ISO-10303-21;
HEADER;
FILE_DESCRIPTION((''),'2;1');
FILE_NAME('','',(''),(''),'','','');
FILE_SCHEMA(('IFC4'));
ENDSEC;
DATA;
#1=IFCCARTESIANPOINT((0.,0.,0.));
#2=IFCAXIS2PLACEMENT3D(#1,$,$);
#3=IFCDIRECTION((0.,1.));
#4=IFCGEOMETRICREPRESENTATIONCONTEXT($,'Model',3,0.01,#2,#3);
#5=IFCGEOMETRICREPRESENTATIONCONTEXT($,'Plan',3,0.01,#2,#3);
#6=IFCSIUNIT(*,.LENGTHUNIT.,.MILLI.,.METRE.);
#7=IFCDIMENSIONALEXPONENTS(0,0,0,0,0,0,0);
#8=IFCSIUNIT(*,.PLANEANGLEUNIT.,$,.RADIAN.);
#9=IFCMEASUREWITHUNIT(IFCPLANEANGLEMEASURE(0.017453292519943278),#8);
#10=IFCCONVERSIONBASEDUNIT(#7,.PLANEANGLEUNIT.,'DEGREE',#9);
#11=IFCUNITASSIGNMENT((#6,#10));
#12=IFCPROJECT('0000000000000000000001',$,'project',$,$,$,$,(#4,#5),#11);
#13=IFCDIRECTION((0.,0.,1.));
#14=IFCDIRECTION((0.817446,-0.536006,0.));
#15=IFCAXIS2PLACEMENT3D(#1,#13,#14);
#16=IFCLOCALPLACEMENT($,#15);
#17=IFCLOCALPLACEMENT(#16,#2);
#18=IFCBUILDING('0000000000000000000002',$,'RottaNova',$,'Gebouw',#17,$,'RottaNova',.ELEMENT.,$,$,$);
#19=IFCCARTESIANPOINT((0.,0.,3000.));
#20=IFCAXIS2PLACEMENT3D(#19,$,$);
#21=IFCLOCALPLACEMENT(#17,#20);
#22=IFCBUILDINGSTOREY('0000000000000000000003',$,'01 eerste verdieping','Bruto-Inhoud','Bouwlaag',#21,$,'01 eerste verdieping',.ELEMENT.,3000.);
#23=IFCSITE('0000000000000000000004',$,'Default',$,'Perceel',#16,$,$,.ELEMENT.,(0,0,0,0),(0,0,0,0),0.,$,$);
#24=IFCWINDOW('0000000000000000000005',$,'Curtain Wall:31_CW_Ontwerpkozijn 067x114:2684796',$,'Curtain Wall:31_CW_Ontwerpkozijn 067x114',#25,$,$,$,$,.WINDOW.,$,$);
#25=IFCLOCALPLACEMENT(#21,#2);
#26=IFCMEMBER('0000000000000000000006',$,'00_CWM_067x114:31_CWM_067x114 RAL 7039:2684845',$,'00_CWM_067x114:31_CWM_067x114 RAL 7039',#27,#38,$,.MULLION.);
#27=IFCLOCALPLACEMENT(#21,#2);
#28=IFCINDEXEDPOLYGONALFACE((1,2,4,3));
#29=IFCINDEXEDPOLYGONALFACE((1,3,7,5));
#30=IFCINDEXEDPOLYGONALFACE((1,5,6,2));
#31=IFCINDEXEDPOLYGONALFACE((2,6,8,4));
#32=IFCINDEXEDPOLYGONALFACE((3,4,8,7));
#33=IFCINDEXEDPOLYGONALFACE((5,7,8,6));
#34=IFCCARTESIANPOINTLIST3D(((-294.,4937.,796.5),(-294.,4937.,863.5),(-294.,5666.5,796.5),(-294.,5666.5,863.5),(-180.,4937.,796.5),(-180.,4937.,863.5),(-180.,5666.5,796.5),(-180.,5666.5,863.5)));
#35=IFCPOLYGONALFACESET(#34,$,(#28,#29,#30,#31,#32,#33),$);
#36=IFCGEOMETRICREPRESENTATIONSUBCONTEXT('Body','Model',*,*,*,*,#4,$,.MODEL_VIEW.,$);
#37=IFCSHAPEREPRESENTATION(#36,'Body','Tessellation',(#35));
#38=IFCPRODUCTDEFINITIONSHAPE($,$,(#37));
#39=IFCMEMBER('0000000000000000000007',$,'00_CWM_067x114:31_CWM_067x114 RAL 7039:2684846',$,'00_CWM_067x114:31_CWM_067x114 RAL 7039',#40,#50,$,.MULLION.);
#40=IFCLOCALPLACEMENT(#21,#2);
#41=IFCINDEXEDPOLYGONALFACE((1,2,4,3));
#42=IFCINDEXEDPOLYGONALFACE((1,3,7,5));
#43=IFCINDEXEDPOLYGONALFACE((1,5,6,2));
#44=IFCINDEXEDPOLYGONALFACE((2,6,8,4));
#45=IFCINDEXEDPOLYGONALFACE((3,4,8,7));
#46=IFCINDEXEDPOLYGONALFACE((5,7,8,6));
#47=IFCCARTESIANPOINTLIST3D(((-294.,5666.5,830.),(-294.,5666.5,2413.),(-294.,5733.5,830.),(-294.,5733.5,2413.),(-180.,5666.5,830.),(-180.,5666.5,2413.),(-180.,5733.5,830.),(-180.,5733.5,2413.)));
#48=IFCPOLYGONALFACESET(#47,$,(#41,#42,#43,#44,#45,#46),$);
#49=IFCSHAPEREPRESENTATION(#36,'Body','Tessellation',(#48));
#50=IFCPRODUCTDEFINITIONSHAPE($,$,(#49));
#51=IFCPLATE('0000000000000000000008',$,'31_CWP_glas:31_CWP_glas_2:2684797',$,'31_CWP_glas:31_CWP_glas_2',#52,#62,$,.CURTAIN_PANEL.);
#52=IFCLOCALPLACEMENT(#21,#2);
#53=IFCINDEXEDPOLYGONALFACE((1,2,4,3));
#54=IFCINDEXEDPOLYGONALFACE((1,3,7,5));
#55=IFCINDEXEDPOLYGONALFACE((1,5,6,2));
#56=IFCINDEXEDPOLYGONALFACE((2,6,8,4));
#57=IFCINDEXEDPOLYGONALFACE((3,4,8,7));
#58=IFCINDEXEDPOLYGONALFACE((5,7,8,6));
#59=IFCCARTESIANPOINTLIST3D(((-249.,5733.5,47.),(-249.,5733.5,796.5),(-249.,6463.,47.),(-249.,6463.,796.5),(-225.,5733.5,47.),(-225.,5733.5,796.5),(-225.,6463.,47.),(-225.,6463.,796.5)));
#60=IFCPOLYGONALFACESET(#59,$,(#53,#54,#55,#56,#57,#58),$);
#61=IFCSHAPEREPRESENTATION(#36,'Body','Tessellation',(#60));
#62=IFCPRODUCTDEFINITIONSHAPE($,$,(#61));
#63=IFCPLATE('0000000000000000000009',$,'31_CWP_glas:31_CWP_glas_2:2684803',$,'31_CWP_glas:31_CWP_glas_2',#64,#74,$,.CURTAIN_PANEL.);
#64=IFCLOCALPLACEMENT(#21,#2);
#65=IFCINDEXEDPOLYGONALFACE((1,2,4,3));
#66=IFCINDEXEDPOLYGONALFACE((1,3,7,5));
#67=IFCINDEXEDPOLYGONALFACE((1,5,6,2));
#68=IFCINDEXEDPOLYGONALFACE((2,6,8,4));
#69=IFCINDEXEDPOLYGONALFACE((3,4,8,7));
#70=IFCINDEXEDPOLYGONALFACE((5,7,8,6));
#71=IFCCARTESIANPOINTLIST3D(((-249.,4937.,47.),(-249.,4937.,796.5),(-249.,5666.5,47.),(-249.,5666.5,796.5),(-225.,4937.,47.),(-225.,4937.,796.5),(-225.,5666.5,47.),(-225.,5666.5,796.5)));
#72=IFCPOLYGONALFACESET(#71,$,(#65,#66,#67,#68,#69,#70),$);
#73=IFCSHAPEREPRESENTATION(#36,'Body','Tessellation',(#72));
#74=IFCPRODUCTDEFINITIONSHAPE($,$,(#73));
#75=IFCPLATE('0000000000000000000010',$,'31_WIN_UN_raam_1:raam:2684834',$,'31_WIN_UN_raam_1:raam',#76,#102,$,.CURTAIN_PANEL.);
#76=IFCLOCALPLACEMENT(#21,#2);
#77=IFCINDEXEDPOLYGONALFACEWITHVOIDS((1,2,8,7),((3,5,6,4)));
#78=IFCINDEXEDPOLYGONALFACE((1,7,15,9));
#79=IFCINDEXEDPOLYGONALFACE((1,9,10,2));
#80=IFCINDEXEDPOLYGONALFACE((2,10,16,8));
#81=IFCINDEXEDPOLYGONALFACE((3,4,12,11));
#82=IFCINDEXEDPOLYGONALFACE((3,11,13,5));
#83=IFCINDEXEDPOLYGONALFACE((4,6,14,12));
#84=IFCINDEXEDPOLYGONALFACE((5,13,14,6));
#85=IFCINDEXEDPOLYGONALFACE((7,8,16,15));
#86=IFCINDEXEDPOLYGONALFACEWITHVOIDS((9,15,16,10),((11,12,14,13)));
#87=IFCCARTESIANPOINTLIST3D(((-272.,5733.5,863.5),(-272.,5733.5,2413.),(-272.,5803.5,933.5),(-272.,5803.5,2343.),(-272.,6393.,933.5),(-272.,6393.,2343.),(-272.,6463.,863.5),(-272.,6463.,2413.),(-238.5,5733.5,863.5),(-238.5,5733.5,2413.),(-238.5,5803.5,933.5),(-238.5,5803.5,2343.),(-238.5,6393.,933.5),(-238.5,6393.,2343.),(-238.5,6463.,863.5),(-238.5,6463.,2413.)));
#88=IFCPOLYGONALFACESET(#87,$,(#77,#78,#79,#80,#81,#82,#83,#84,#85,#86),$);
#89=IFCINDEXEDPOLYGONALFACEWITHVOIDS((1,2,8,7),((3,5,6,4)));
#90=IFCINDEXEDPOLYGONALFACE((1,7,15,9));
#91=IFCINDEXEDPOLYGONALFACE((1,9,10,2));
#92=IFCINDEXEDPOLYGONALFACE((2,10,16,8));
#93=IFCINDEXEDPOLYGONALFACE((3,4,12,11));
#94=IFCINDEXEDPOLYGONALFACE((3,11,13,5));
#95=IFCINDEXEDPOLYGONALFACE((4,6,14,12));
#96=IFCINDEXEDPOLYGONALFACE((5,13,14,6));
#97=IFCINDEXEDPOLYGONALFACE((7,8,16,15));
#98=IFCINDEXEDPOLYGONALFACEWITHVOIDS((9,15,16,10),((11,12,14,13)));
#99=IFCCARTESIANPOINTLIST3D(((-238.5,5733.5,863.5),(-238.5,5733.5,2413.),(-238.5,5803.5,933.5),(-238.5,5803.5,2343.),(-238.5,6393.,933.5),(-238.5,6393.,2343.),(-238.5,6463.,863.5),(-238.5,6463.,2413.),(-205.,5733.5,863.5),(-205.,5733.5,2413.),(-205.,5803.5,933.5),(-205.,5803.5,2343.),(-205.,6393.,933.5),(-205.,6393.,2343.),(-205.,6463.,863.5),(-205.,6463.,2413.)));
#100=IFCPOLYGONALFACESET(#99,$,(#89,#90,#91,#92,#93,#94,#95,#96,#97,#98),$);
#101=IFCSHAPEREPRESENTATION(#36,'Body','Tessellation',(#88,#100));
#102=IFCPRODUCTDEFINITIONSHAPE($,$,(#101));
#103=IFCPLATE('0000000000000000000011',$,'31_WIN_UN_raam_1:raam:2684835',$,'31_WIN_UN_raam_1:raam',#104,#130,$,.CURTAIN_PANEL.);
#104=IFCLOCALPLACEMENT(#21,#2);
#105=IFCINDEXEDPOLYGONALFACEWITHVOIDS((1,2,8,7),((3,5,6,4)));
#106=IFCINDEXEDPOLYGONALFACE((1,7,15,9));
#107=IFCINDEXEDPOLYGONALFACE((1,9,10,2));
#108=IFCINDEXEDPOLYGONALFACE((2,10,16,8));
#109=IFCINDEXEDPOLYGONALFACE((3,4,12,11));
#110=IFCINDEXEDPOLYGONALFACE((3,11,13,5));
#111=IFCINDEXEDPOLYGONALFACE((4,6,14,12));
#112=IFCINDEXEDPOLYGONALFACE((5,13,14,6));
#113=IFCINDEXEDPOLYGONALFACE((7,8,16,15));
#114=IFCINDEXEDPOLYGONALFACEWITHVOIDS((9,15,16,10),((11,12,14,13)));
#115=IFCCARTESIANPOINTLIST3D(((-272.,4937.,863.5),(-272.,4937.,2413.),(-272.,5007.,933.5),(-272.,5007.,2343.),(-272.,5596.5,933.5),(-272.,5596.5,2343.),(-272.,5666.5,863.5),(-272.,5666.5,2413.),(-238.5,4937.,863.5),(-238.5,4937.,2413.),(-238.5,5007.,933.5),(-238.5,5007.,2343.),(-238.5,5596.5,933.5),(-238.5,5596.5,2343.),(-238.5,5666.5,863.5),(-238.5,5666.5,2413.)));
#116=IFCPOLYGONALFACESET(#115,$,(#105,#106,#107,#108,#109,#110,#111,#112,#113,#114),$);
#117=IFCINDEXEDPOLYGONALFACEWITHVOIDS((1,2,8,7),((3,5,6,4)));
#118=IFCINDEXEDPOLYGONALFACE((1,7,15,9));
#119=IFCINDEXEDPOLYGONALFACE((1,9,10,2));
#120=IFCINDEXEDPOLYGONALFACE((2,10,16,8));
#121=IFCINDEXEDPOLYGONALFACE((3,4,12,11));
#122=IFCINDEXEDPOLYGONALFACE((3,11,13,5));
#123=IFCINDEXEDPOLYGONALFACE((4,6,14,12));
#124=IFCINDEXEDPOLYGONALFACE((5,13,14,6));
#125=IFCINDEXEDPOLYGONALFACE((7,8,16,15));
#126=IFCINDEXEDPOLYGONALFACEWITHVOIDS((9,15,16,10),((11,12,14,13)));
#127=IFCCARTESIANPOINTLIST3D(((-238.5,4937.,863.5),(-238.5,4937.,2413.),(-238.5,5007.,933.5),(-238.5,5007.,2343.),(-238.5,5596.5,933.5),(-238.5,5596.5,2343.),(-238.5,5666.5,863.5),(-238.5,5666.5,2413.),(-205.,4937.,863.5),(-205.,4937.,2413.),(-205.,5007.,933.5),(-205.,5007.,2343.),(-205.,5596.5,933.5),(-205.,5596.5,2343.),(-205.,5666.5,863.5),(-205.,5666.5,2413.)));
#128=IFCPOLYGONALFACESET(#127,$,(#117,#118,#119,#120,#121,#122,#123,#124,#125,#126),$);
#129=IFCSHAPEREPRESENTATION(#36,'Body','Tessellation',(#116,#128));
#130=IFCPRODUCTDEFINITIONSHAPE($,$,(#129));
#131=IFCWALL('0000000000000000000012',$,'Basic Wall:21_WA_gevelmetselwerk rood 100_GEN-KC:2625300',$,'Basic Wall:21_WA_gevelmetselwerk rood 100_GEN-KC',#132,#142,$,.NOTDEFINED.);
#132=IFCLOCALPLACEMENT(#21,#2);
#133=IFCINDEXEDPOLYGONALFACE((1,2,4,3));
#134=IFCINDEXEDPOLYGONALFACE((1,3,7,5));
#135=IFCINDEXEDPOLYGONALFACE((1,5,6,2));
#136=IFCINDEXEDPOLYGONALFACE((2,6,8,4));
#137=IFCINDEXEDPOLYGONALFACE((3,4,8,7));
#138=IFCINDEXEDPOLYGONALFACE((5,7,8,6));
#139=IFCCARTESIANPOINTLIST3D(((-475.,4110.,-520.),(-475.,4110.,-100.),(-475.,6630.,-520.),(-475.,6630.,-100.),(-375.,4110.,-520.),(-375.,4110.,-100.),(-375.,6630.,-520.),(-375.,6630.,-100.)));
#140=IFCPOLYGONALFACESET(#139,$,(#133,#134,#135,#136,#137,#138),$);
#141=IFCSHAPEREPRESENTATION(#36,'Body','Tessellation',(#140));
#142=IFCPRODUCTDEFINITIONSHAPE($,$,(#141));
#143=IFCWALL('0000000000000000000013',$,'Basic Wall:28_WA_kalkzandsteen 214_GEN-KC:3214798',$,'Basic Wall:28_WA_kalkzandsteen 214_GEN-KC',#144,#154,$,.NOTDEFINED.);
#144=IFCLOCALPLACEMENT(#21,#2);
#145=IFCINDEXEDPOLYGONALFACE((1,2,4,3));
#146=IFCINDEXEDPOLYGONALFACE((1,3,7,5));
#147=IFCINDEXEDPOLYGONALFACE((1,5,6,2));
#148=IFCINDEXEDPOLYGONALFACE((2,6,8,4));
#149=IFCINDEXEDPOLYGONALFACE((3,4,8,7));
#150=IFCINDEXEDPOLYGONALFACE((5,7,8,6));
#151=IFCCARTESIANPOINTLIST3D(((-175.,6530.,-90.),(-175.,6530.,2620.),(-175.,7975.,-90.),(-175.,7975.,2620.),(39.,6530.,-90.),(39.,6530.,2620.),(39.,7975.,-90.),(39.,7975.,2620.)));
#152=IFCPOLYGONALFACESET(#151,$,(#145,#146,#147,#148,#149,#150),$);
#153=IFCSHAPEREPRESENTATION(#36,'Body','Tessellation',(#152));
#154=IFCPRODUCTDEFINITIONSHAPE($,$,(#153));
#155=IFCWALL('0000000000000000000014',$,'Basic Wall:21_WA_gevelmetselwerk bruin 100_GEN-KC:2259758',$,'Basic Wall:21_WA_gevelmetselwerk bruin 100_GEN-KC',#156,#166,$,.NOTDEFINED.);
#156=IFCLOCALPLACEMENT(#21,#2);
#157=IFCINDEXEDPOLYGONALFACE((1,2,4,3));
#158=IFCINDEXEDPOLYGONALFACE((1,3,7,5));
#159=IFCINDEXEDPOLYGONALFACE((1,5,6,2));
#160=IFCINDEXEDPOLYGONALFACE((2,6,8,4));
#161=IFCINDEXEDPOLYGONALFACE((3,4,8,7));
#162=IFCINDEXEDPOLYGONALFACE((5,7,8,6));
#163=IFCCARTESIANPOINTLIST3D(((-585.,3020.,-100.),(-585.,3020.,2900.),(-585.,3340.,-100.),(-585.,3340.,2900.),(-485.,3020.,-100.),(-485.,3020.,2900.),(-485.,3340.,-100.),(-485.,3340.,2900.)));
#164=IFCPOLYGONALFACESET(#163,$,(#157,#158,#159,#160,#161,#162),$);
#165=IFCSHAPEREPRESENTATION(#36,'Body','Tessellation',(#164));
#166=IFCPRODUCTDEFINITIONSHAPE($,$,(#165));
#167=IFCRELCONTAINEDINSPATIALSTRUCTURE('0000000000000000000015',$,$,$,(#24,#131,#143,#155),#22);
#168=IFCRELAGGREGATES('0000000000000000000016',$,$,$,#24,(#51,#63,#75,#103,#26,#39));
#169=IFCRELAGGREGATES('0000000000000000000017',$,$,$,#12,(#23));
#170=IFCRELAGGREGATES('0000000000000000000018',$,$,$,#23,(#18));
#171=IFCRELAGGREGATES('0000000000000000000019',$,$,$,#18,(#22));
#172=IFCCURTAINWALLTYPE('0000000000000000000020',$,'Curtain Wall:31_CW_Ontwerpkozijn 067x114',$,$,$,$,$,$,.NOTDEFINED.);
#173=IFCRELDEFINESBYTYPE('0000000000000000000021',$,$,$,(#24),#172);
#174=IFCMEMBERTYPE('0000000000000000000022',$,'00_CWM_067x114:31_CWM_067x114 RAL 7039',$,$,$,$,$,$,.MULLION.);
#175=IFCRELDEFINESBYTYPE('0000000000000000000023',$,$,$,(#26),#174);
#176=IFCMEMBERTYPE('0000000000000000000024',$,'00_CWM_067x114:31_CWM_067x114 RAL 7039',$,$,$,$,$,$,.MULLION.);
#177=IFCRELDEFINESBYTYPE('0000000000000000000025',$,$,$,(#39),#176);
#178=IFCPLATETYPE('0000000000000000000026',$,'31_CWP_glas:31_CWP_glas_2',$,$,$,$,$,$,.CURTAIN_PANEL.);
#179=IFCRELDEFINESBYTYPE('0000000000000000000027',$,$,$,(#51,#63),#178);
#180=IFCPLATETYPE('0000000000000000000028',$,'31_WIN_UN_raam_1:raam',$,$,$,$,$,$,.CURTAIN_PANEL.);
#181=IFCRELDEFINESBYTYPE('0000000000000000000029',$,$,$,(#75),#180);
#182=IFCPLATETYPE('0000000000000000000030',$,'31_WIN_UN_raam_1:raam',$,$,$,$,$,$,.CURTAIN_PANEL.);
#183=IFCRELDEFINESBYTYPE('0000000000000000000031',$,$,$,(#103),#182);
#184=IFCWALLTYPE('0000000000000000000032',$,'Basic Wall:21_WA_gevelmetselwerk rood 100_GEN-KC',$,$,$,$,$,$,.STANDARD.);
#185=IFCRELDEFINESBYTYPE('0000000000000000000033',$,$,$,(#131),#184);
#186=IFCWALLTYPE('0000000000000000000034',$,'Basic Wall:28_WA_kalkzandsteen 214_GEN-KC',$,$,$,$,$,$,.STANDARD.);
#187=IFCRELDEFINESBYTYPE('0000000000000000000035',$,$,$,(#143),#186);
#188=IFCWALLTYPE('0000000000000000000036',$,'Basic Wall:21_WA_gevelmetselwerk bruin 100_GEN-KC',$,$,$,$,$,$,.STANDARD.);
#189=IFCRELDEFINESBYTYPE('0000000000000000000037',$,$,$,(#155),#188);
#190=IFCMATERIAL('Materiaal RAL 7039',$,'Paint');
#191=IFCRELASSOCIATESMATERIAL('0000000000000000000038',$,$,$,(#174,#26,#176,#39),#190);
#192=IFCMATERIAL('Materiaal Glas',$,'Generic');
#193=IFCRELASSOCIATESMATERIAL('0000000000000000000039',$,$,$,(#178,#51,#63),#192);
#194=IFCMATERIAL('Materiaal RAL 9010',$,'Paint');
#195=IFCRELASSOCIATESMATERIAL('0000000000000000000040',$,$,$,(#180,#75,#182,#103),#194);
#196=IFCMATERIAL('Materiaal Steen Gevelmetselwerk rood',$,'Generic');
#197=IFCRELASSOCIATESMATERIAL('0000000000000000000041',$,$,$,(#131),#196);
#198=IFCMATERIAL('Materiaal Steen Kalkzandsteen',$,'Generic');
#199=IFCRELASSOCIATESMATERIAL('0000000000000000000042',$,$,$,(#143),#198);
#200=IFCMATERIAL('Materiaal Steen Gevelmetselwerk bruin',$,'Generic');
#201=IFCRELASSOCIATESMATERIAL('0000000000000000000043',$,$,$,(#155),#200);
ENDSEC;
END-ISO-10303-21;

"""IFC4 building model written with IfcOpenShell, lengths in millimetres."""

from ifc_helpers import new_model, entity, si_unit, converted_unit, direction, frame, origin, place, context, subcontext, project, spatial, indexed_curve, outline, extrude, source, transform, mapped, material, type_object, type_shapes, element, aggregate, save


model = new_model("IFC4")

# Units and contexts
model_context = context("Model", 3, precision=0.01, world=origin(), true_north=direction((0.0, 1.0)))
plan_context = context("Plan", 3, precision=0.01, world=origin(), true_north=direction((0.0, 1.0)))
body_context = subcontext(model_context, "Body", "Model", "MODEL_VIEW")
ifc_project = project(units=[si_unit("LENGTHUNIT", "METRE", prefix="MILLI"), converted_unit("PLANEANGLEUNIT", "DEGREE", entity("IfcPlaneAngleMeasure", 0.017453292519943278), si_unit("PLANEANGLEUNIT", "RADIAN"), dimensions=[0, 0, 0, 0, 0, 0, 0])], contexts=[model_context, plan_context])

# Site, building, storey
site_placement = place(None, frame((0.0, 0.0, 0.0), z_axis=(0.0, 0.0, 1.0), x_axis=(0.817446, -0.536006, 0.0)))
site = spatial("IfcSite", under=ifc_project, at=site_placement, Name="Default", ObjectType="Perceel", CompositionType="ELEMENT", RefLatitude=(0, 0, 0, 0), RefLongitude=(0, 0, 0, 0), RefElevation=0.0)
building_placement = place(site_placement, origin())
building = spatial("IfcBuilding", under=site, at=building_placement, Name="RottaNova", ObjectType="Gebouw", LongName="RottaNova", CompositionType="ELEMENT")
storey_placement = place(building_placement, frame((0.0, 0.0, 3000.0)))
storey = spatial("IfcBuildingStorey", under=building, at=storey_placement, Name="01 eerste verdieping", Description="Bruto-Inhoud", ObjectType="Bouwlaag", LongName="01 eerste verdieping", CompositionType="ELEMENT", Elevation=3000.0)

# Window, members, plates
curtain_wall_type = type_object("IfcCurtainWallType", Name="Curtain Wall:31_CW_Ontwerpkozijn 067x114", PredefinedType="NOTDEFINED")
window_placement = place(storey_placement, frame((0.0, 0.0, -3000.0)))
window = element("IfcWindow", 1, at=window_placement, inside=storey, type_object=curtain_wall_type, Name="Curtain Wall:31_CW_Ontwerpkozijn 067x114:2684796", ObjectType="Curtain Wall:31_CW_Ontwerpkozijn 067x114", PredefinedType="WINDOW")
ifc_material_1 = material(Name="Materiaal RAL 7039", Category="Paint")
member_type_1 = type_object("IfcMemberType", Name="00_CWM_067x114:31_CWM_067x114 RAL 7039", PredefinedType="MULLION", material=ifc_material_1)
shared_shape_1 = source(origin(), body_context, "Body", "SweptSolid", [
    extrude(outline(indexed_curve([(-33.5, -57.0), (33.5, -57.0), (33.5, 57.0), (-33.5, 57.0), (-33.5, -57.0)], self_intersect=False)), frame((0.0, 57.0, -729.5), z_axis=(0.0, 0.0, 1.0), x_axis=(-1.0, 0.0, 0.0)), (0.0, 0.0, 1.0), 729.5),
])
type_shapes(member_type_1, [shared_shape_1])
member_1_placement = place(window_placement, frame((-180.0, 4937.0, 3830.0), z_axis=(0.0, -1.0, 0.0), x_axis=(0.0, 0.0, 1.0)))
member_1 = element("IfcMember", 2, at=member_1_placement, type_object=member_type_1, material=ifc_material_1, Name="00_CWM_067x114:31_CWM_067x114 RAL 7039:2684845", ObjectType="00_CWM_067x114:31_CWM_067x114 RAL 7039", PredefinedType="MULLION", context=body_context, shape_type="MappedRepresentation", body=[
    mapped(shared_shape_1, transform((0.0, 0.0, 0.0), scale=1.0)),
])
member_type_2 = type_object("IfcMemberType", Name="00_CWM_067x114:31_CWM_067x114 RAL 7039", PredefinedType="MULLION", material=ifc_material_1)
shared_shape_2 = source(origin(), body_context, "Body", "SweptSolid", [
    extrude(outline(indexed_curve([(-33.5, -57.0), (33.5, -57.0), (33.5, 57.0), (-33.5, 57.0), (-33.5, -57.0)], self_intersect=False)), frame((0.0, 57.0, -1583.0), z_axis=(0.0, 0.0, 1.0), x_axis=(-1.0, 0.0, 0.0)), (0.0, 0.0, 1.0), 1583.0),
])
type_shapes(member_type_2, [shared_shape_2])
member_2_placement = place(window_placement, frame((-180.0, 5700.0, 3830.0), z_axis=(0.0, 0.0, -1.0), x_axis=(0.0, -1.0, 0.0)))
member_2 = element("IfcMember", 3, at=member_2_placement, type_object=member_type_2, material=ifc_material_1, Name="00_CWM_067x114:31_CWM_067x114 RAL 7039:2684846", ObjectType="00_CWM_067x114:31_CWM_067x114 RAL 7039", PredefinedType="MULLION", context=body_context, shape_type="MappedRepresentation", body=[
    mapped(shared_shape_2, transform((0.0, 0.0, 0.0), scale=1.0)),
])
ifc_material_2 = material(Name="Materiaal Glas", Category="Generic")
plate_type_1 = type_object("IfcPlateType", Name="31_CWP_glas:31_CWP_glas_2", PredefinedType="CURTAIN_PANEL", material=ifc_material_2)
shared_shape_3 = source(origin(), body_context, "Body", "SweptSolid", [
    extrude(outline(indexed_curve([(-12.0, -364.7), (12.0, -364.7), (12.0, 364.7), (-12.0, 364.7), (-12.0, -364.7)], self_intersect=False)), frame((0.0, -57.0, 0.0), z_axis=(0.0, 0.0, 1.0), x_axis=(0.0, 1.0, 0.0)), (0.0, 0.0, 1.0), 749.5),
])
type_shapes(plate_type_1, [shared_shape_3])
plate_1_placement = place(window_placement, frame((-180.0, 6098.2, 3047.0), z_axis=(0.0, 0.0, 1.0), x_axis=(0.0, -1.0, 0.0)))
plate_1 = element("IfcPlate", 4, at=plate_1_placement, type_object=plate_type_1, material=ifc_material_2, Name="31_CWP_glas:31_CWP_glas_2:2684797", ObjectType="31_CWP_glas:31_CWP_glas_2", PredefinedType="CURTAIN_PANEL", context=body_context, shape_type="MappedRepresentation", body=[
    mapped(shared_shape_3, transform((0.0, 0.0, 0.0), scale=1.0)),
])
plate_2_placement = place(window_placement, frame((-180.0, 5301.7, 3047.0), z_axis=(0.0, 0.0, 1.0), x_axis=(0.0, -1.0, 0.0)))
plate_2 = element("IfcPlate", 5, at=plate_2_placement, type_object=plate_type_1, material=ifc_material_2, Name="31_CWP_glas:31_CWP_glas_2:2684803", ObjectType="31_CWP_glas:31_CWP_glas_2", PredefinedType="CURTAIN_PANEL", context=body_context, shape_type="MappedRepresentation", body=[
    mapped(shared_shape_3, transform((0.0, 0.0, 0.0), scale=1.0)),
])
ifc_material_3 = material(Name="Materiaal RAL 9010", Category="Paint")
plate_type_2 = type_object("IfcPlateType", Name="31_WIN_UN_raam_1:raam", PredefinedType="CURTAIN_PANEL", material=ifc_material_3)
shared_shape_4 = source(origin(), body_context, "Body", "SweptSolid", [
    extrude(outline(indexed_curve([(-364.7, -774.7), (364.7, -774.7), (364.7, 774.7), (-364.7, 774.7), (-364.7, -774.7)], self_intersect=False), holes=[indexed_curve([(-294.7, 704.7), (294.7, 704.7), (294.7, -704.8), (-294.7, -704.8), (-294.7, 704.7)], self_intersect=False)]), frame((0.0, -92.0, 774.8), z_axis=(0.0, 1.0, 0.0), x_axis=(1.0, 0.0, 0.0)), (0.0, 0.0, 1.0), 33.5),
    extrude(outline(indexed_curve([(-364.7, -774.7), (364.7, -774.7), (364.7, 774.7), (-364.7, 774.7), (-364.7, -774.7)], self_intersect=False), holes=[indexed_curve([(-294.7, 704.7), (294.7, 704.7), (294.7, -704.8), (-294.7, -704.8), (-294.7, 704.7)], self_intersect=False)]), frame((0.0, -58.5, 774.8), z_axis=(0.0, 1.0, 0.0), x_axis=(1.0, 0.0, 0.0)), (0.0, 0.0, 1.0), 33.5),
])
type_shapes(plate_type_2, [shared_shape_4])
plate_3_placement = place(window_placement, frame((-180.0, 6098.2, 3863.5), z_axis=(0.0, 0.0, 1.0), x_axis=(0.0, -1.0, 0.0)))
plate_3 = element("IfcPlate", 6, at=plate_3_placement, type_object=plate_type_2, material=ifc_material_3, Name="31_WIN_UN_raam_1:raam:2684834", ObjectType="31_WIN_UN_raam_1:raam", PredefinedType="CURTAIN_PANEL", context=body_context, shape_type="MappedRepresentation", body=[
    mapped(shared_shape_4, transform((0.0, 0.0, 0.0), scale=1.0)),
])
plate_type_3 = type_object("IfcPlateType", Name="31_WIN_UN_raam_1:raam", PredefinedType="CURTAIN_PANEL", material=ifc_material_3)
shared_shape_5 = source(origin(), body_context, "Body", "SweptSolid", [
    extrude(outline(indexed_curve([(-364.7, -774.7), (364.7, -774.7), (364.7, 774.7), (-364.7, 774.7), (-364.7, -774.7)], self_intersect=False), holes=[indexed_curve([(-294.7, 704.7), (294.7, 704.7), (294.7, -704.8), (-294.7, -704.8), (-294.7, 704.7)], self_intersect=False)]), frame((0.0, -92.0, 774.8), z_axis=(0.0, 1.0, 0.0), x_axis=(1.0, 0.0, 0.0)), (0.0, 0.0, 1.0), 33.5),
    extrude(outline(indexed_curve([(-364.7, -774.7), (364.7, -774.7), (364.7, 774.7), (-364.7, 774.7), (-364.7, -774.7)], self_intersect=False), holes=[indexed_curve([(-294.7, 704.7), (294.7, 704.7), (294.7, -704.8), (-294.7, -704.8), (-294.7, 704.7)], self_intersect=False)]), frame((0.0, -58.5, 774.8), z_axis=(0.0, 1.0, 0.0), x_axis=(1.0, 0.0, 0.0)), (0.0, 0.0, 1.0), 33.5),
])
type_shapes(plate_type_3, [shared_shape_5])
plate_4_placement = place(window_placement, frame((-180.0, 5301.7, 3863.5), z_axis=(0.0, 0.0, 1.0), x_axis=(0.0, -1.0, 0.0)))
plate_4 = element("IfcPlate", 7, at=plate_4_placement, type_object=plate_type_3, material=ifc_material_3, Name="31_WIN_UN_raam_1:raam:2684835", ObjectType="31_WIN_UN_raam_1:raam", PredefinedType="CURTAIN_PANEL", context=body_context, shape_type="MappedRepresentation", body=[
    mapped(shared_shape_5, transform((0.0, 0.0, 0.0), scale=1.0)),
])
aggregate(window, [plate_1, plate_2, plate_3, plate_4, member_1, member_2])

# Walls
ifc_material_4 = material(Name="Materiaal Steen Gevelmetselwerk rood", Category="Generic")
wall_type_1 = type_object("IfcWallType", Name="Basic Wall:21_WA_gevelmetselwerk rood 100_GEN-KC", PredefinedType="STANDARD")
wall_1_placement = place(storey_placement, frame((-425.0, 6630.0, -520.0), z_axis=(0.0, 0.0, 1.0), x_axis=(0.0, -1.0, 0.0)))
element("IfcWall", 8, at=wall_1_placement, inside=storey, type_object=wall_type_1, material=ifc_material_4, Name="Basic Wall:21_WA_gevelmetselwerk rood 100_GEN-KC:2625300", ObjectType="Basic Wall:21_WA_gevelmetselwerk rood 100_GEN-KC", PredefinedType="NOTDEFINED", context=body_context, shape_type="SweptSolid", body=[
    extrude(outline(indexed_curve([(2520.0, 50.0), (0.0, 50.0), (0.0, -50.0), (2520.0, -50.0), (2520.0, 50.0)], self_intersect=False)), origin(), (0.0, 0.0, 1.0), 420.0),
])
ifc_material_5 = material(Name="Materiaal Steen Kalkzandsteen", Category="Generic")
wall_type_2 = type_object("IfcWallType", Name="Basic Wall:28_WA_kalkzandsteen 214_GEN-KC", PredefinedType="STANDARD")
wall_2_placement = place(storey_placement, frame((-68.0, 6530.0, -90.0), z_axis=(0.0, 0.0, 1.0), x_axis=(0.0, 1.0, 0.0)))
element("IfcWall", 9, at=wall_2_placement, inside=storey, type_object=wall_type_2, material=ifc_material_5, Name="Basic Wall:28_WA_kalkzandsteen 214_GEN-KC:3214798", ObjectType="Basic Wall:28_WA_kalkzandsteen 214_GEN-KC", PredefinedType="NOTDEFINED", context=body_context, shape_type="SweptSolid", body=[
    extrude(outline(indexed_curve([(1445.0, 107.0), (0.0, 107.0), (0.0, -107.0), (1445.0, -107.0), (1445.0, 107.0)], self_intersect=False)), origin(), (0.0, 0.0, 1.0), 2710.0),
])
ifc_material_6 = material(Name="Materiaal Steen Gevelmetselwerk bruin", Category="Generic")
wall_type_3 = type_object("IfcWallType", Name="Basic Wall:21_WA_gevelmetselwerk bruin 100_GEN-KC", PredefinedType="STANDARD")
wall_3_placement = place(storey_placement, frame((-535.0, 3340.0, -100.0), z_axis=(0.0, 0.0, 1.0), x_axis=(0.0, -1.0, 0.0)))
element("IfcWall", 10, at=wall_3_placement, inside=storey, type_object=wall_type_3, material=ifc_material_6, Name="Basic Wall:21_WA_gevelmetselwerk bruin 100_GEN-KC:2259758", ObjectType="Basic Wall:21_WA_gevelmetselwerk bruin 100_GEN-KC", PredefinedType="NOTDEFINED", context=body_context, shape_type="SweptSolid", body=[
    extrude(outline(indexed_curve([(320.0, 50.0), (0.0, 50.0), (0.0, -50.0), (320.0, -50.0), (320.0, 50.0)], self_intersect=False)), origin(), (0.0, 0.0, 1.0), 3000.0),
])

save(model, "model.ifc")
